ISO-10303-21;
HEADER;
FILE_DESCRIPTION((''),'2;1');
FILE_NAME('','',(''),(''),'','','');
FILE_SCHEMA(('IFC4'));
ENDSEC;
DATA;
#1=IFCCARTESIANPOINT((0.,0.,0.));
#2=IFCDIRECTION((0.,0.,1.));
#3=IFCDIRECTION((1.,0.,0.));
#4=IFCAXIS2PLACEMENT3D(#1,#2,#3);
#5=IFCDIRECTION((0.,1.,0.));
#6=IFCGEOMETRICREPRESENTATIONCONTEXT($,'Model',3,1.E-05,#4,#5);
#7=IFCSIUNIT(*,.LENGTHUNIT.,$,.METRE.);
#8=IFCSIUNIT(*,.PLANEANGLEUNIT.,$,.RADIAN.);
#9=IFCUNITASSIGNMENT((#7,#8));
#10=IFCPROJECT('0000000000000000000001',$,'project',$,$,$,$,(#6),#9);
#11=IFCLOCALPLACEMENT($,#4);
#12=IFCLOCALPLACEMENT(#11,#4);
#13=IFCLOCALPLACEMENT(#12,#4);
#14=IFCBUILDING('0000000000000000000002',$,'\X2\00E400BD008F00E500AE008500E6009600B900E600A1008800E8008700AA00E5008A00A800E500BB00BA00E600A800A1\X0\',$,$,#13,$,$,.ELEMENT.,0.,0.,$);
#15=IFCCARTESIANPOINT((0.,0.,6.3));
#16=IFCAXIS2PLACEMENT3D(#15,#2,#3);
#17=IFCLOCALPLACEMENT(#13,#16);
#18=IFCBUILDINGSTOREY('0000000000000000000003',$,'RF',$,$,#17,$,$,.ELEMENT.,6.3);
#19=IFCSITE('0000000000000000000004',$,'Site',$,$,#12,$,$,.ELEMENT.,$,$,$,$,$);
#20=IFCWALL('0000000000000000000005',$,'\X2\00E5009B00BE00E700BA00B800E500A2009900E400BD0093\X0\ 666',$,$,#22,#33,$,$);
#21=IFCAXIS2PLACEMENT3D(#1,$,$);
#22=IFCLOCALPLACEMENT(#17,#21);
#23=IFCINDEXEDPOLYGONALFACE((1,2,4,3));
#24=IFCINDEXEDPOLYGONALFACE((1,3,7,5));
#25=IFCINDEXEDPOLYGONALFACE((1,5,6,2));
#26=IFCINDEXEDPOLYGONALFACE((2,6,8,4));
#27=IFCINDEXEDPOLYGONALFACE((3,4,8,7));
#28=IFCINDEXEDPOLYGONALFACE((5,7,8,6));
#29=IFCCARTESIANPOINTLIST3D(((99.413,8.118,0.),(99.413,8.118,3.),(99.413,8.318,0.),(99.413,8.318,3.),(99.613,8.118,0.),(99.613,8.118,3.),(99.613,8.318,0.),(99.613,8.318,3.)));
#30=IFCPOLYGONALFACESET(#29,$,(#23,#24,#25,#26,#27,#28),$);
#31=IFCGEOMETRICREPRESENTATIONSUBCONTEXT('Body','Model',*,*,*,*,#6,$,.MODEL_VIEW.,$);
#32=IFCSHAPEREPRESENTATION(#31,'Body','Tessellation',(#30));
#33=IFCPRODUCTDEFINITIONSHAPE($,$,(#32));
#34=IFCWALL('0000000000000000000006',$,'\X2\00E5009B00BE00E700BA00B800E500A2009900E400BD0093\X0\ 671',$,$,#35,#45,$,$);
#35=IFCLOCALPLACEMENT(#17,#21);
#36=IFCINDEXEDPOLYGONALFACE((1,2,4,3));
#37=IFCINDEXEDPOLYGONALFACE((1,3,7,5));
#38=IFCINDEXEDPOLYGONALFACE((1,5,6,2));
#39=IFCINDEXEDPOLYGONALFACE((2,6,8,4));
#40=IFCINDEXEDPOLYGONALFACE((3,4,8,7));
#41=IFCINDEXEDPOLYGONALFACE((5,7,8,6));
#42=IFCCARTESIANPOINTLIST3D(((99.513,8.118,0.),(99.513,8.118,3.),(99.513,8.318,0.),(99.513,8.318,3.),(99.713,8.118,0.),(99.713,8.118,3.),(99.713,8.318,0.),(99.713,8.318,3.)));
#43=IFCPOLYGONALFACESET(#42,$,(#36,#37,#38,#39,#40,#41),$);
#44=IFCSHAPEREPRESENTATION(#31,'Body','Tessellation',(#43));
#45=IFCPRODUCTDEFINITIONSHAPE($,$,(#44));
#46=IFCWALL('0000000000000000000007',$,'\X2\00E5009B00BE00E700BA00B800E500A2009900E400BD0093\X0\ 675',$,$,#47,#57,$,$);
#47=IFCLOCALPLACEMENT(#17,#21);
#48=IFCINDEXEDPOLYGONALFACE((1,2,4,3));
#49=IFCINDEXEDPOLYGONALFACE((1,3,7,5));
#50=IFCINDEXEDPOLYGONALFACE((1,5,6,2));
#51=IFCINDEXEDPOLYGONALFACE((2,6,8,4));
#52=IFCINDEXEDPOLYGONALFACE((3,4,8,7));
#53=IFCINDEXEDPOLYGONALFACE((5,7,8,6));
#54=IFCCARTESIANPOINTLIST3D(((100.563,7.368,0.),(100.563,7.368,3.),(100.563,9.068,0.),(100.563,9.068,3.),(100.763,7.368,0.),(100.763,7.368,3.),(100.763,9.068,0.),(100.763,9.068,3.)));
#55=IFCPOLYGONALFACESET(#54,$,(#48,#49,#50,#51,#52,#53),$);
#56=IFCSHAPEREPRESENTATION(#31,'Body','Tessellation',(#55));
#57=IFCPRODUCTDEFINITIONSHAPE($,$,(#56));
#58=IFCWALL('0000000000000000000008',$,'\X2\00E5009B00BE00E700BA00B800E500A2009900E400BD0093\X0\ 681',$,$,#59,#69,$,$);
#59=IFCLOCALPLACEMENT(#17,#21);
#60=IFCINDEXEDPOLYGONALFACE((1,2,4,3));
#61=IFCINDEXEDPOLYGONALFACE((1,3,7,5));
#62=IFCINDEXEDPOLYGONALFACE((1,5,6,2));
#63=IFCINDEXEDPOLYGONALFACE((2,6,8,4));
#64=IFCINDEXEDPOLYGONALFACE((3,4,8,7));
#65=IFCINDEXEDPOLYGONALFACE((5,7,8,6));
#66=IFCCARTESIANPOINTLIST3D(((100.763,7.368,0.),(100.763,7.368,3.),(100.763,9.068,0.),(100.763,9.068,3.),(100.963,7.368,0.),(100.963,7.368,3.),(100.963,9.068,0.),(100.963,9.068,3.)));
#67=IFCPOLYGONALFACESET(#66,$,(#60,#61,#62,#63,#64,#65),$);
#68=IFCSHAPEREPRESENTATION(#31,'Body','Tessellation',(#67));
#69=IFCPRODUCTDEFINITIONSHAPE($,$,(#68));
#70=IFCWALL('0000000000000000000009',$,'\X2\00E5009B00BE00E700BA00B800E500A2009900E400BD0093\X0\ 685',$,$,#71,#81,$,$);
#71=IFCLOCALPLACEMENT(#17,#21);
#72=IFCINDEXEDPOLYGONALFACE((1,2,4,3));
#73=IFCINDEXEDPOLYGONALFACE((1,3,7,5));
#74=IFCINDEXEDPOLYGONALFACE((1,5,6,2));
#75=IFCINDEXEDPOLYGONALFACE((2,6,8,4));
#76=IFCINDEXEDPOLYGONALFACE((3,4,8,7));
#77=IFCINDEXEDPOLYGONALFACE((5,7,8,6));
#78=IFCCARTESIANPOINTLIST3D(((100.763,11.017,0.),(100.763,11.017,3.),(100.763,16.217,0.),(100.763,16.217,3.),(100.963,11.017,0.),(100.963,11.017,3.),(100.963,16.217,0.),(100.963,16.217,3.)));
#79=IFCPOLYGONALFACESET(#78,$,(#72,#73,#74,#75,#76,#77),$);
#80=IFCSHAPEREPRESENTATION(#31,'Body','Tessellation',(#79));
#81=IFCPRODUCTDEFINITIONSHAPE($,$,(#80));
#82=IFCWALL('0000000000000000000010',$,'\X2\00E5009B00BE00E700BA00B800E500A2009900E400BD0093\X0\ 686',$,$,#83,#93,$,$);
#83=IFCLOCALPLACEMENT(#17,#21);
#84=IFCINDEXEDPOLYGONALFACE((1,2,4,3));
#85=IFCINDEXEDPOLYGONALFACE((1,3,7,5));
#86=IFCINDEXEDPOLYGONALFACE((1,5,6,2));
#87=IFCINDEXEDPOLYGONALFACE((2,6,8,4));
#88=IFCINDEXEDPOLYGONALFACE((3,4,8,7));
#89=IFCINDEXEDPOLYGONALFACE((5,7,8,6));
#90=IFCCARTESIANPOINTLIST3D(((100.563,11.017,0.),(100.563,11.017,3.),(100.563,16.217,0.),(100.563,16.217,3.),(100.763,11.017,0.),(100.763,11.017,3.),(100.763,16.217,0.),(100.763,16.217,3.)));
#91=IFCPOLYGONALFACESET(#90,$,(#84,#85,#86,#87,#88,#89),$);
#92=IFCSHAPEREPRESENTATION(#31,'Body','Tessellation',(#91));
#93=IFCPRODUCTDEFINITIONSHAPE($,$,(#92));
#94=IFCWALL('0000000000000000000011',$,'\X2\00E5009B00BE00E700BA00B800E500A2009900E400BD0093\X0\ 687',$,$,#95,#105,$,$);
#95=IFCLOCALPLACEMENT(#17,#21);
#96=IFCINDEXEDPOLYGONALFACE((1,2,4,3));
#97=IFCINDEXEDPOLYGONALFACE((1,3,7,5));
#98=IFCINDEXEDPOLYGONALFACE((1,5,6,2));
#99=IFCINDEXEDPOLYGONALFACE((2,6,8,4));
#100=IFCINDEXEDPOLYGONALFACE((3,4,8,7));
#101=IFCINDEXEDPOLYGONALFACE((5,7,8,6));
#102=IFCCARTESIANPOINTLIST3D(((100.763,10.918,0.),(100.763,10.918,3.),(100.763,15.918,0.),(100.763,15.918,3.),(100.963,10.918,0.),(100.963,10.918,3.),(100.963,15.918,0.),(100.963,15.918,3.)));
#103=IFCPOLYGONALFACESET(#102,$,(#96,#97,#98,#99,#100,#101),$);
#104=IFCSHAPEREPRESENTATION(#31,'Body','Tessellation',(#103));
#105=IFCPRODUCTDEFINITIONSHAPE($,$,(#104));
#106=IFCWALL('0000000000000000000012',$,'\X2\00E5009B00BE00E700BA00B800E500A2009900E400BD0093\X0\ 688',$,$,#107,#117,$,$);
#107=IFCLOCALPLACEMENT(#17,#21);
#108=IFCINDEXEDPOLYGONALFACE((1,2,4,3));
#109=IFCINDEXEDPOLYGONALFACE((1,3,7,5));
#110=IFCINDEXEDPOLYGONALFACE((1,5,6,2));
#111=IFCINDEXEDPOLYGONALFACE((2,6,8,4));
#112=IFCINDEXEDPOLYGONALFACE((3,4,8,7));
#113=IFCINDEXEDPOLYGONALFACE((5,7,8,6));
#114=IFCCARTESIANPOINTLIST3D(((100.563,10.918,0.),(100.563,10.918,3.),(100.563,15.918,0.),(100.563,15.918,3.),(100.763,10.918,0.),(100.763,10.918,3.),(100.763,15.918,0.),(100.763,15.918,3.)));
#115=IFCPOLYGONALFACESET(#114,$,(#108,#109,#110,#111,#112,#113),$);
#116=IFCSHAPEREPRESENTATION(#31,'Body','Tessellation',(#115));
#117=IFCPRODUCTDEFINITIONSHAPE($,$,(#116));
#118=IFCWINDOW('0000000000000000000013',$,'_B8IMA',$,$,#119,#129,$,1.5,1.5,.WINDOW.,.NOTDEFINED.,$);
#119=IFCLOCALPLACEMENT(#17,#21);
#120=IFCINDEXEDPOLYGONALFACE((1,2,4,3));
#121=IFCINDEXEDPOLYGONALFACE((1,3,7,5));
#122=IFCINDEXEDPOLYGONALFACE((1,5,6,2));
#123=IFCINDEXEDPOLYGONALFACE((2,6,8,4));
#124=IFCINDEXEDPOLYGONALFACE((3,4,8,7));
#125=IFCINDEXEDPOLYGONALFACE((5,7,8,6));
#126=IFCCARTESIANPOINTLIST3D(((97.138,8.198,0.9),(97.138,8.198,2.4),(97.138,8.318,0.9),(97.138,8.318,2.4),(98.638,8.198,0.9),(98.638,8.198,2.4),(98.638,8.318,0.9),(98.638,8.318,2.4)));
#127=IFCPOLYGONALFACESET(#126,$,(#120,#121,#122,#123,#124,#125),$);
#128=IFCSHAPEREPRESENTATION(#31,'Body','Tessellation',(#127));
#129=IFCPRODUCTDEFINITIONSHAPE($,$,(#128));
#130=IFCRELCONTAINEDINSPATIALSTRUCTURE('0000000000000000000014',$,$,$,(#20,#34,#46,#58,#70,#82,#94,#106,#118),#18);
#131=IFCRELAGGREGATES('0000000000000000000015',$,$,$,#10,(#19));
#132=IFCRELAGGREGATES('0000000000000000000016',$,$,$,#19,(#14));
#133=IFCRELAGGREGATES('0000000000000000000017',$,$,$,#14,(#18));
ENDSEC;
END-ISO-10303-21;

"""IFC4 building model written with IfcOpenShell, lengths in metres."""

from ifc_helpers import new_model, si_unit, direction, frame, frame_2d, origin_with_axes, place, context, subcontext, project, spatial, rectangle, extrude, element, save


model = new_model("IFC4")

# Units and contexts
model_context = context("Model", 3, precision=1e-05, world=origin_with_axes(), true_north=direction((0.0, 1.0, 0.0)))
body_context = subcontext(model_context, "Body", "Model", "MODEL_VIEW")
ifc_project = project(units=[si_unit("LENGTHUNIT", "METRE"), si_unit("PLANEANGLEUNIT", "RADIAN")], contexts=[model_context])

# Site, building, storey
placement = place(None, origin_with_axes())
site_placement = place(placement, origin_with_axes())
site = spatial("IfcSite", under=ifc_project, at=site_placement, Name="Site", CompositionType="ELEMENT")
building_placement = place(site_placement, origin_with_axes())
building = spatial("IfcBuilding", under=site, at=building_placement, Name="ä½\u008få®\u0085æ\u0096¹æ¡\u0088è\u0087ªå\u008a¨å»ºæ¨¡", CompositionType="ELEMENT", ElevationOfRefHeight=0.0, ElevationOfTerrain=0.0)
storey_placement = place(building_placement, frame((0.0, 0.0, 6.3), z_axis=(0.0, 0.0, 1.0), x_axis=(1.0, 0.0, 0.0)))
storey = spatial("IfcBuildingStorey", under=building, at=storey_placement, Name="RF", CompositionType="ELEMENT", Elevation=6.3)

# Walls
for number, where, z_axis, x_axis, name in (
    (1, (99.513, 8.218, 0.0), (0.0, 0.0, 1.0), (0.0, 1.0, 0.0), "å\u009b¾çº¸å¢\u0099ä½\u0093 666"),
    (2, (99.613, 8.218, 0.0), (0.0, 0.0, 1.0), (0.0, -1.0, 0.0), "å\u009b¾çº¸å¢\u0099ä½\u0093 671"),
):
    element("IfcWall", number, at=place(storey_placement, frame(where, z_axis=z_axis, x_axis=x_axis)), inside=storey, Name=name, context=body_context, shape_type="SweptSolid", body=[
        extrude(rectangle(XDim=0.2, YDim=0.2, at=frame_2d((0.0, 0.0), x_axis=(1.0, 0.0, 0.0))), frame((0.0, 0.0, 0.0), z_axis=(0.0, 0.0, 1.0)), (0.0, 0.0, 1.0), 3.0),
    ])
for number, where, z_axis, x_axis, name in (
    (3, (100.663, 8.218, 0.0), (0.0, 0.0, 1.0), (0.0, -1.0, 0.0), "å\u009b¾çº¸å¢\u0099ä½\u0093 675"),
    (4, (100.863, 8.218, 0.0), (0.0, 0.0, 1.0), (0.0, -1.0, 0.0), "å\u009b¾çº¸å¢\u0099ä½\u0093 681"),
):
    element("IfcWall", number, at=place(storey_placement, frame(where, z_axis=z_axis, x_axis=x_axis)), inside=storey, Name=name, context=body_context, shape_type="SweptSolid", body=[
        extrude(rectangle(XDim=1.7, YDim=0.2, at=frame_2d((0.0, 0.0), x_axis=(1.0, 0.0, 0.0))), frame((0.0, 0.0, 0.0), z_axis=(0.0, 0.0, 1.0)), (0.0, 0.0, 1.0), 3.0),
    ])
for number, where, z_axis, x_axis, name in (
    (5, (100.863, 13.617, 0.0), (0.0, 0.0, 1.0), (0.0, -1.0, 0.0), "å\u009b¾çº¸å¢\u0099ä½\u0093 685"),
    (6, (100.663, 13.617, 0.0), (0.0, 0.0, 1.0), (0.0, -1.0, 0.0), "å\u009b¾çº¸å¢\u0099ä½\u0093 686"),
):
    element("IfcWall", number, at=place(storey_placement, frame(where, z_axis=z_axis, x_axis=x_axis)), inside=storey, Name=name, context=body_context, shape_type="SweptSolid", body=[
        extrude(rectangle(XDim=5.2, YDim=0.2, at=frame_2d((0.0, 0.0), x_axis=(1.0, 0.0, 0.0))), frame((0.0, 0.0, 0.0), z_axis=(0.0, 0.0, 1.0)), (0.0, 0.0, 1.0), 3.0),
    ])
for number, where, z_axis, x_axis, name in (
    (7, (100.863, 13.418, 0.0), (0.0, 0.0, 1.0), (0.0, -1.0, 0.0), "å\u009b¾çº¸å¢\u0099ä½\u0093 687"),
    (8, (100.663, 13.418, 0.0), (0.0, 0.0, 1.0), (0.0, -1.0, 0.0), "å\u009b¾çº¸å¢\u0099ä½\u0093 688"),
):
    element("IfcWall", number, at=place(storey_placement, frame(where, z_axis=z_axis, x_axis=x_axis)), inside=storey, Name=name, context=body_context, shape_type="SweptSolid", body=[
        extrude(rectangle(XDim=5.0, YDim=0.2, at=frame_2d((0.0, 0.0), x_axis=(1.0, 0.0, 0.0))), frame((0.0, 0.0, 0.0), z_axis=(0.0, 0.0, 1.0)), (0.0, 0.0, 1.0), 3.0),
    ])

# Window
window_placement = place(storey_placement, frame((97.888, 8.258, 0.9), z_axis=(0.0, 0.0, 1.0), x_axis=(1.0, 0.0, 0.0)))
element("IfcWindow", 9, at=window_placement, inside=storey, Name="_B8IMA", OverallHeight=1.5, OverallWidth=1.5, PartitioningType="NOTDEFINED", PredefinedType="WINDOW", context=body_context, shape_type="SweptSolid", body=[
    extrude(rectangle(XDim=1.5, YDim=0.12, at=frame_2d((0.0, 0.0), x_axis=(1.0, 0.0, 0.0))), frame((0.0, 0.0, 0.0), z_axis=(0.0, 0.0, 1.0)), (0.0, 0.0, 1.0), 1.5),
])

save(model, "model.ifc")
